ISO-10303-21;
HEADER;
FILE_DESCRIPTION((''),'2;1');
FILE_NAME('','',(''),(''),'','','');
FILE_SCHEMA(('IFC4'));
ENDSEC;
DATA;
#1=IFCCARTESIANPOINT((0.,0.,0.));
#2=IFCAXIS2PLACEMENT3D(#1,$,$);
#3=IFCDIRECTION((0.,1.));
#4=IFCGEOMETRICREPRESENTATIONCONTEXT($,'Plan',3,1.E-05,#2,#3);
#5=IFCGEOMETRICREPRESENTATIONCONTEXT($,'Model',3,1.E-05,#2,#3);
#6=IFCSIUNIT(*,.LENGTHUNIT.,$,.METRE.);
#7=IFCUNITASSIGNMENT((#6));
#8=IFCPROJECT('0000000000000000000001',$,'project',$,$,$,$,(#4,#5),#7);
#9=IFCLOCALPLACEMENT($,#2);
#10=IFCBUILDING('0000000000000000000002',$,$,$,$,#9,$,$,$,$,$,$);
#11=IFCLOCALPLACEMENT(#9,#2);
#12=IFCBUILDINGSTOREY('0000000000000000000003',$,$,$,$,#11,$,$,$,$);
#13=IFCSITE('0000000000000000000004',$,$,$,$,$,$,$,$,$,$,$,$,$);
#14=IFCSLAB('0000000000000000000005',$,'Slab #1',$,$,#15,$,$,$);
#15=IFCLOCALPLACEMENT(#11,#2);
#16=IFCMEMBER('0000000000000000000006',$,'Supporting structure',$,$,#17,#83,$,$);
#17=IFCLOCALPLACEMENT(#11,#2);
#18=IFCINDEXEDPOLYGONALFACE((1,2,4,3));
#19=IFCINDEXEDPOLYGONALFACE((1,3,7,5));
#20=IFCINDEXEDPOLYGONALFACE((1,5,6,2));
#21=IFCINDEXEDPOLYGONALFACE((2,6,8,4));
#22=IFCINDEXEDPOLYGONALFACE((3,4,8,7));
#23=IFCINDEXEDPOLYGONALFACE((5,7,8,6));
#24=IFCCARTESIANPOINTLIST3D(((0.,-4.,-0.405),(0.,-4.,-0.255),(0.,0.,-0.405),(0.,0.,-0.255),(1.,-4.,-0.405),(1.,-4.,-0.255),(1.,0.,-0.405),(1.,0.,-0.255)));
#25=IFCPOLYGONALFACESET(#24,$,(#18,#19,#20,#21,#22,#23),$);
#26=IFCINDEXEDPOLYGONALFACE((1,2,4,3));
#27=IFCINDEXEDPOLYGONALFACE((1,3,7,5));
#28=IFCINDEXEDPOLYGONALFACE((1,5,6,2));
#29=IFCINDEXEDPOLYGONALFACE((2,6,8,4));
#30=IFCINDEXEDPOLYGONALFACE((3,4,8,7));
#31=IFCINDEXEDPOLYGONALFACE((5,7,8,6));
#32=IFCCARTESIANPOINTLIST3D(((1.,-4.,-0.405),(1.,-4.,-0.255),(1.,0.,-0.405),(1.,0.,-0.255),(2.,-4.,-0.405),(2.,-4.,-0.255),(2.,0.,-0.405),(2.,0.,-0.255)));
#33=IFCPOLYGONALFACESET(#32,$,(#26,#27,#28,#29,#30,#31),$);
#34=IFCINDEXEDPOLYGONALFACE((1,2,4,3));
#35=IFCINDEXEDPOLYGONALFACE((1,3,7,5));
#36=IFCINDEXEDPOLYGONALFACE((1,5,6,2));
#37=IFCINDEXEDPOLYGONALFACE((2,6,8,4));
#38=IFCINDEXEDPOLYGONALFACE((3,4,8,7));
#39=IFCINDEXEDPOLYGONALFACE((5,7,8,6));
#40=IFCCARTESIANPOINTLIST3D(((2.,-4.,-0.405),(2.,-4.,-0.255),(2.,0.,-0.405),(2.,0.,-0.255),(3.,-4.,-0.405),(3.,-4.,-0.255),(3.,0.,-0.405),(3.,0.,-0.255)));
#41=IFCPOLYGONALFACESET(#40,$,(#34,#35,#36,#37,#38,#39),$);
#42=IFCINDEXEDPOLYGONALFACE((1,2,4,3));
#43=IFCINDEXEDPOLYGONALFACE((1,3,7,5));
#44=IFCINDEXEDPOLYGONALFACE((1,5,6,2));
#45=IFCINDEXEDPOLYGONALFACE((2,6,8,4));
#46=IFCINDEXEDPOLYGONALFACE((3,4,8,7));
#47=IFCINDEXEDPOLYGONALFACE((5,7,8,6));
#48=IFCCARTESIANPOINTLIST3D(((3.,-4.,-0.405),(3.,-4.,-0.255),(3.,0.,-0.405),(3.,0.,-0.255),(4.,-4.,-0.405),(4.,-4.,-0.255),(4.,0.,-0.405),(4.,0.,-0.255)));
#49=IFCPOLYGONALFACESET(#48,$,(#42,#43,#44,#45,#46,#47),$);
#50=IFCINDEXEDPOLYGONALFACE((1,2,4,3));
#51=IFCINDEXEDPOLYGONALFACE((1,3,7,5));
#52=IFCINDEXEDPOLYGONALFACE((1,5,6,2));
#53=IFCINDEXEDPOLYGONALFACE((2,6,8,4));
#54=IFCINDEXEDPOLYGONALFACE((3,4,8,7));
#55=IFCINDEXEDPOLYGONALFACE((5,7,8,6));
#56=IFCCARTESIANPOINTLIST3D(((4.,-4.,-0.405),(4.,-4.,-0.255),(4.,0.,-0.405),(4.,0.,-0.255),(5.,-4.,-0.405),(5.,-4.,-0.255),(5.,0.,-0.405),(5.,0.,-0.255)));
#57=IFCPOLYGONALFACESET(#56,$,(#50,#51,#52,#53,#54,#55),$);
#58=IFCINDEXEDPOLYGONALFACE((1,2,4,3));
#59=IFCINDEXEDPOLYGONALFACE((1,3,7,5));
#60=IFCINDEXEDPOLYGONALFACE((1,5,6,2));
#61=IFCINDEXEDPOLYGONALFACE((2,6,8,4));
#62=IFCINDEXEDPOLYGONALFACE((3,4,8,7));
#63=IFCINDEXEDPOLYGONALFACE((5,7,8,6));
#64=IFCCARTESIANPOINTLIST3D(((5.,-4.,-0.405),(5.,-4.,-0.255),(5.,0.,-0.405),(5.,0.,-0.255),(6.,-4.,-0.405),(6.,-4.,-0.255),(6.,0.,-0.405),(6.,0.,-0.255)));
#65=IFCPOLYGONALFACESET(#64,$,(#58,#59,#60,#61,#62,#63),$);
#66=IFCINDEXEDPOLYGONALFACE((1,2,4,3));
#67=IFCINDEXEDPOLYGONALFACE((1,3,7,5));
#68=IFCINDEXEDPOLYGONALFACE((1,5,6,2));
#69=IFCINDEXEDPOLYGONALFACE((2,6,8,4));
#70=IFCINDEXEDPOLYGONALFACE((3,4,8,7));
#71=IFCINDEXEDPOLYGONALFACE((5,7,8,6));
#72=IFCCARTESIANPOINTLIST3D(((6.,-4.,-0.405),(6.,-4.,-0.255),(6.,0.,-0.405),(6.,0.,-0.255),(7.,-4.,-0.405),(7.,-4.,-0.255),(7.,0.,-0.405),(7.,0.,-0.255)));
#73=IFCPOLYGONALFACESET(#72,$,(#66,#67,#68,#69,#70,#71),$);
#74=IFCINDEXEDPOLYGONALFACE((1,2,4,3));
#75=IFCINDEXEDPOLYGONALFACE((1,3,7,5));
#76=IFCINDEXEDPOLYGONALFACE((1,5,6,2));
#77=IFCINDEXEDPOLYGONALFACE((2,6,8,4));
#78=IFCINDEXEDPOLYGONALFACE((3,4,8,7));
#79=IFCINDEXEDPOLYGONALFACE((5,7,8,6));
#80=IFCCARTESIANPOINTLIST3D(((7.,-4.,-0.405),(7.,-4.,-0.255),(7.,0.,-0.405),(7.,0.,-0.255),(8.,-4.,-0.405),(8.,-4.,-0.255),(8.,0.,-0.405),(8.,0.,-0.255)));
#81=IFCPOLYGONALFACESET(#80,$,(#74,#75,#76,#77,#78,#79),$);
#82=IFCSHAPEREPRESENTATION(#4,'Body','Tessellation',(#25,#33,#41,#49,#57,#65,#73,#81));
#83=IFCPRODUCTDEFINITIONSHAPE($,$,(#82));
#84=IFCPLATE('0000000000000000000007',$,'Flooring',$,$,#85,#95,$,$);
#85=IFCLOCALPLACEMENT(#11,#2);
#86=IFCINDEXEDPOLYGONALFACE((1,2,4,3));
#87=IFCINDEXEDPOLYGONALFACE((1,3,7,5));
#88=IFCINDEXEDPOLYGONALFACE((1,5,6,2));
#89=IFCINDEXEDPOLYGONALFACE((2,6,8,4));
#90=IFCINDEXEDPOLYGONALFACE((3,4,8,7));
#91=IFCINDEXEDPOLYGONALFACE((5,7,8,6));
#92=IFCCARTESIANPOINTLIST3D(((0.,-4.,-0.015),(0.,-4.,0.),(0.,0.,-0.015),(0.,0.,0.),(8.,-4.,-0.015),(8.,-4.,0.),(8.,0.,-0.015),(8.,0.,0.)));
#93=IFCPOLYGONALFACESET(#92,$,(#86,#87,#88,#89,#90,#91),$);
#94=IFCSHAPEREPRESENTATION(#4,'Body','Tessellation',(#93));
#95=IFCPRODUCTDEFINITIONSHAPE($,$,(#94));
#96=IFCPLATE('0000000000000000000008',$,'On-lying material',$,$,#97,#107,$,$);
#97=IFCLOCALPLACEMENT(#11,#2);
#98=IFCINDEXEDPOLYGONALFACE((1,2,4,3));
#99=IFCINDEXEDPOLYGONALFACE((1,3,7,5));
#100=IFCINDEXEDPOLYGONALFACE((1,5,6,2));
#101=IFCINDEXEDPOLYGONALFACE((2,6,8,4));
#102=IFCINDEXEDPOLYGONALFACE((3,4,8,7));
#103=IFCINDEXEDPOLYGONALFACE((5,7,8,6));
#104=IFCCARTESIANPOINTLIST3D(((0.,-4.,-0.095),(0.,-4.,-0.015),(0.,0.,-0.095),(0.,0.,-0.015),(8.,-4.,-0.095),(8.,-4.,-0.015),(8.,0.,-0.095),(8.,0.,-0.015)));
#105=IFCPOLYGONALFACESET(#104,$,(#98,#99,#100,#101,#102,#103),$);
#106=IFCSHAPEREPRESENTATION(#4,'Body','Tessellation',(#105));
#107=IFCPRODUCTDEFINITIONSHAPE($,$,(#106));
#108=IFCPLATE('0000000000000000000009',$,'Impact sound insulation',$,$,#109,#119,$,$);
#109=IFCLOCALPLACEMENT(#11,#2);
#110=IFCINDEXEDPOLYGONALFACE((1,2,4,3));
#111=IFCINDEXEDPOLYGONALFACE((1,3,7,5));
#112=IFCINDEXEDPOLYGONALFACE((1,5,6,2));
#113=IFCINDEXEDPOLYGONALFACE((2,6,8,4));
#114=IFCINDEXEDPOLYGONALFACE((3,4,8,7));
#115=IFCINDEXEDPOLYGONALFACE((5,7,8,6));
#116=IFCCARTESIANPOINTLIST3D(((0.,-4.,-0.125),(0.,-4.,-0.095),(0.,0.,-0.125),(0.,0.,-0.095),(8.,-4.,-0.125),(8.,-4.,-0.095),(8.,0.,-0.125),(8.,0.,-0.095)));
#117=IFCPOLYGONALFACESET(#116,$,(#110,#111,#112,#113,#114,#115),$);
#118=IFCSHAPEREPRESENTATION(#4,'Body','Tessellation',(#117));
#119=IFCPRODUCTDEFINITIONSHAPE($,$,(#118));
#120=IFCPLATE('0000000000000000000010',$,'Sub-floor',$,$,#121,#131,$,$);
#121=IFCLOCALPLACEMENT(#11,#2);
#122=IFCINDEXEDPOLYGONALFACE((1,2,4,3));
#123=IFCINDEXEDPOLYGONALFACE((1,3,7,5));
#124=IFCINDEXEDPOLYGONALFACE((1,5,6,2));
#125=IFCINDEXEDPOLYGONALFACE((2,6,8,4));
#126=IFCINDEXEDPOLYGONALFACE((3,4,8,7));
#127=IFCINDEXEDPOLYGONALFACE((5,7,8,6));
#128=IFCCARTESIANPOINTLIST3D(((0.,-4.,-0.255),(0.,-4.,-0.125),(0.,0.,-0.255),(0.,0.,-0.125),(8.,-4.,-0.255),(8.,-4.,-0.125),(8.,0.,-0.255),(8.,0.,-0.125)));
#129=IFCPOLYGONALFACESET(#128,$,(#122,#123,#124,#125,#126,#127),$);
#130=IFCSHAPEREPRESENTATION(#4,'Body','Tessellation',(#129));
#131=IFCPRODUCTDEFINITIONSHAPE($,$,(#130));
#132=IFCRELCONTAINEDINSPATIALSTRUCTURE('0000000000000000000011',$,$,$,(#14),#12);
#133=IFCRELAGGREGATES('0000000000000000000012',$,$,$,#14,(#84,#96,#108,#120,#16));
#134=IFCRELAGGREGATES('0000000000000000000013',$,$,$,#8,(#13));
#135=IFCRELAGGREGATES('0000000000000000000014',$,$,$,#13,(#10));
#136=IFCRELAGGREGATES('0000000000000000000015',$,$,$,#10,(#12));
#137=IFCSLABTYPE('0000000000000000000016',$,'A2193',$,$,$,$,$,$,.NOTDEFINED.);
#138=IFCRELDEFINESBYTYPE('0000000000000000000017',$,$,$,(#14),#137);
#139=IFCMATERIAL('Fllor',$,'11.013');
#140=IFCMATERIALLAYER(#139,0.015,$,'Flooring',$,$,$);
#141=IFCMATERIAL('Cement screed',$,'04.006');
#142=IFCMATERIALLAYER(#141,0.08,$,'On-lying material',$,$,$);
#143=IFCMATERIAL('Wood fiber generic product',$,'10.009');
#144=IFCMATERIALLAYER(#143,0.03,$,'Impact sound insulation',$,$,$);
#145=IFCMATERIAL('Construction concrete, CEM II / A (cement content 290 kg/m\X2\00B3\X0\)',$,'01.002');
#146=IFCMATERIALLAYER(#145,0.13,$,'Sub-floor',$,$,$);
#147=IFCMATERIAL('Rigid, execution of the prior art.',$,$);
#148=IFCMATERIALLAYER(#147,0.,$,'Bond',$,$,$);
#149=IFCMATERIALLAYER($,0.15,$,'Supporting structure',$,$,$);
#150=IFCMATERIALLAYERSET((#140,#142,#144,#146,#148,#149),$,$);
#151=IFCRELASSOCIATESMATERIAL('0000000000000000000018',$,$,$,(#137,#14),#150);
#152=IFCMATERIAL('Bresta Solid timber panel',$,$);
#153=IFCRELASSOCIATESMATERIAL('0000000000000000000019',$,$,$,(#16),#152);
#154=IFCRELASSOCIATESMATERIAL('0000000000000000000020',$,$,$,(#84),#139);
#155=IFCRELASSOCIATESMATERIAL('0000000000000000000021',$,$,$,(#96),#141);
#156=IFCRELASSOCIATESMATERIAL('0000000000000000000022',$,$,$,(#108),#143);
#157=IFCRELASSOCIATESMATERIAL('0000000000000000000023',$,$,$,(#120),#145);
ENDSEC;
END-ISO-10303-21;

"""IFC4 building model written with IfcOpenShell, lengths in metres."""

from ifc_helpers import new_model, si_unit, direction, frame, frame_2d, origin, origin_with_axes, place, context, project, spatial, rectangle, extrude, material, layer, layer_set, type_object, element, aggregate, save


model = new_model("IFC4")

# Units and contexts
plan_context = context("Plan", 3, precision=1e-05, world=origin(), true_north=direction((0.0, 1.0)))
model_context = context("Model", 3, precision=1e-05, world=origin(), true_north=direction((0.0, 1.0)))
ifc_project = project(units=[si_unit("LENGTHUNIT", "METRE")], contexts=[plan_context, model_context])

# Site, building, storey
site = spatial("IfcSite", under=ifc_project)
building_placement = place(None, origin())
building = spatial("IfcBuilding", under=site, at=building_placement)
storey_placement = place(building_placement, origin())
storey = spatial("IfcBuildingStorey", under=building, at=storey_placement)

# Slab, member, plates
ifc_material_1 = material(Name="Fllor", Category="11.013")
ifc_layer_1 = layer(ifc_material_1, 0.015, Name="Flooring")
ifc_material_2 = material(Name="Cement screed", Category="04.006")
ifc_layer_2 = layer(ifc_material_2, 0.08, Name="On-lying material")
ifc_material_3 = material(Name="Wood fiber generic product", Category="10.009")
ifc_layer_3 = layer(ifc_material_3, 0.03, Name="Impact sound insulation")
ifc_material_4 = material(Name="Construction concrete, CEM II / A (cement content 290 kg/m³)", Category="01.002")
ifc_layer_4 = layer(ifc_material_4, 0.13, Name="Sub-floor")
ifc_material_5 = material(Name="Rigid, execution of the prior art.")
ifc_layer_5 = layer(ifc_material_5, 0.0, Name="Bond")
ifc_layer_6 = layer(None, 0.15, Name="Supporting structure")
ifc_layer_set = layer_set([ifc_layer_1, ifc_layer_2, ifc_layer_3, ifc_layer_4, ifc_layer_5, ifc_layer_6])
slab_type = type_object("IfcSlabType", Name="A2193", PredefinedType="NOTDEFINED", material=ifc_layer_set)
slab_placement = place(None, frame((0.0, 0.0, 0.0), z_axis=(0.0, 0.0, -1.0), x_axis=(1.0, 0.0, 0.0)))
slab = element("IfcSlab", 1, at=slab_placement, inside=storey, type_object=slab_type, material=ifc_layer_set, Name="Slab #1")
ifc_material_6 = material(Name="Bresta Solid timber panel")
member_placement = place(slab_placement, origin())
member = element("IfcMember", 2, at=member_placement, material=ifc_material_6, Name="Supporting structure", context=plan_context, shape_type="SweptSolid", body=[
    extrude(rectangle(XDim=1.0, YDim=0.15, at=frame_2d((0.5, 0.075), x_axis=(1.0, 0.0))), frame((0.0, 4.0, 0.255), z_axis=(0.0, -1.0, 0.0), x_axis=(1.0, 0.0, 0.0)), (0.0, 0.0, 1.0), 4.0),
    extrude(rectangle(XDim=1.0, YDim=0.15, at=frame_2d((0.5, 0.075), x_axis=(1.0, 0.0))), frame((1.0, 4.0, 0.255), z_axis=(0.0, -1.0, 0.0), x_axis=(1.0, 0.0, 0.0)), (0.0, 0.0, 1.0), 4.0),
    extrude(rectangle(XDim=1.0, YDim=0.15, at=frame_2d((0.5, 0.075), x_axis=(1.0, 0.0))), frame((2.0, 4.0, 0.255), z_axis=(0.0, -1.0, 0.0), x_axis=(1.0, 0.0, 0.0)), (0.0, 0.0, 1.0), 4.0),
    extrude(rectangle(XDim=1.0, YDim=0.15, at=frame_2d((0.5, 0.075), x_axis=(1.0, 0.0))), frame((3.0, 4.0, 0.255), z_axis=(0.0, -1.0, 0.0), x_axis=(1.0, 0.0, 0.0)), (0.0, 0.0, 1.0), 4.0),
    extrude(rectangle(XDim=1.0, YDim=0.15, at=frame_2d((0.5, 0.075), x_axis=(1.0, 0.0))), frame((4.0, 4.0, 0.255), z_axis=(0.0, -1.0, 0.0), x_axis=(1.0, 0.0, 0.0)), (0.0, 0.0, 1.0), 4.0),
    extrude(rectangle(XDim=1.0, YDim=0.15, at=frame_2d((0.5, 0.075), x_axis=(1.0, 0.0))), frame((5.0, 4.0, 0.255), z_axis=(0.0, -1.0, 0.0), x_axis=(1.0, 0.0, 0.0)), (0.0, 0.0, 1.0), 4.0),
    extrude(rectangle(XDim=1.0, YDim=0.15, at=frame_2d((0.5, 0.075), x_axis=(1.0, 0.0))), frame((6.0, 4.0, 0.255), z_axis=(0.0, -1.0, 0.0), x_axis=(1.0, 0.0, 0.0)), (0.0, 0.0, 1.0), 4.0),
    extrude(rectangle(XDim=1.0, YDim=0.15, at=frame_2d((0.5, 0.075), x_axis=(1.0, 0.0))), frame((7.0, 4.0, 0.255), z_axis=(0.0, -1.0, 0.0), x_axis=(1.0, 0.0, 0.0)), (0.0, 0.0, 1.0), 4.0),
])
plate_1_placement = place(slab_placement, origin())
plate_1 = element("IfcPlate", 3, at=plate_1_placement, material=ifc_material_1, Name="Flooring", context=plan_context, shape_type="SweptSolid", body=[
    extrude(rectangle(XDim=8.0, YDim=4.0, at=frame_2d((4.0, 2.0), x_axis=(1.0, 0.0))), origin_with_axes(), (0.0, 0.0, 1.0), 0.015),
])
plate_2_placement = place(slab_placement, origin())
plate_2 = element("IfcPlate", 4, at=plate_2_placement, material=ifc_material_2, Name="On-lying material", context=plan_context, shape_type="SweptSolid", body=[
    extrude(rectangle(XDim=8.0, YDim=4.0, at=frame_2d((4.0, 2.0), x_axis=(1.0, 0.0))), frame((0.0, 0.0, 0.015), z_axis=(0.0, 0.0, 1.0), x_axis=(1.0, 0.0, 0.0)), (0.0, 0.0, 1.0), 0.08),
])
plate_3_placement = place(slab_placement, origin())
plate_3 = element("IfcPlate", 5, at=plate_3_placement, material=ifc_material_3, Name="Impact sound insulation", context=plan_context, shape_type="SweptSolid", body=[
    extrude(rectangle(XDim=8.0, YDim=4.0, at=frame_2d((4.0, 2.0), x_axis=(1.0, 0.0))), frame((0.0, 0.0, 0.095), z_axis=(0.0, 0.0, 1.0), x_axis=(1.0, 0.0, 0.0)), (0.0, 0.0, 1.0), 0.03),
])
plate_4_placement = place(slab_placement, origin())
plate_4 = element("IfcPlate", 6, at=plate_4_placement, material=ifc_material_4, Name="Sub-floor", context=plan_context, shape_type="SweptSolid", body=[
    extrude(rectangle(XDim=8.0, YDim=4.0, at=frame_2d((4.0, 2.0), x_axis=(1.0, 0.0))), frame((0.0, 0.0, 0.125), z_axis=(0.0, 0.0, 1.0), x_axis=(1.0, 0.0, 0.0)), (0.0, 0.0, 1.0), 0.13),
])
aggregate(slab, [plate_1, plate_2, plate_3, plate_4, member])

save(model, "model.ifc")
